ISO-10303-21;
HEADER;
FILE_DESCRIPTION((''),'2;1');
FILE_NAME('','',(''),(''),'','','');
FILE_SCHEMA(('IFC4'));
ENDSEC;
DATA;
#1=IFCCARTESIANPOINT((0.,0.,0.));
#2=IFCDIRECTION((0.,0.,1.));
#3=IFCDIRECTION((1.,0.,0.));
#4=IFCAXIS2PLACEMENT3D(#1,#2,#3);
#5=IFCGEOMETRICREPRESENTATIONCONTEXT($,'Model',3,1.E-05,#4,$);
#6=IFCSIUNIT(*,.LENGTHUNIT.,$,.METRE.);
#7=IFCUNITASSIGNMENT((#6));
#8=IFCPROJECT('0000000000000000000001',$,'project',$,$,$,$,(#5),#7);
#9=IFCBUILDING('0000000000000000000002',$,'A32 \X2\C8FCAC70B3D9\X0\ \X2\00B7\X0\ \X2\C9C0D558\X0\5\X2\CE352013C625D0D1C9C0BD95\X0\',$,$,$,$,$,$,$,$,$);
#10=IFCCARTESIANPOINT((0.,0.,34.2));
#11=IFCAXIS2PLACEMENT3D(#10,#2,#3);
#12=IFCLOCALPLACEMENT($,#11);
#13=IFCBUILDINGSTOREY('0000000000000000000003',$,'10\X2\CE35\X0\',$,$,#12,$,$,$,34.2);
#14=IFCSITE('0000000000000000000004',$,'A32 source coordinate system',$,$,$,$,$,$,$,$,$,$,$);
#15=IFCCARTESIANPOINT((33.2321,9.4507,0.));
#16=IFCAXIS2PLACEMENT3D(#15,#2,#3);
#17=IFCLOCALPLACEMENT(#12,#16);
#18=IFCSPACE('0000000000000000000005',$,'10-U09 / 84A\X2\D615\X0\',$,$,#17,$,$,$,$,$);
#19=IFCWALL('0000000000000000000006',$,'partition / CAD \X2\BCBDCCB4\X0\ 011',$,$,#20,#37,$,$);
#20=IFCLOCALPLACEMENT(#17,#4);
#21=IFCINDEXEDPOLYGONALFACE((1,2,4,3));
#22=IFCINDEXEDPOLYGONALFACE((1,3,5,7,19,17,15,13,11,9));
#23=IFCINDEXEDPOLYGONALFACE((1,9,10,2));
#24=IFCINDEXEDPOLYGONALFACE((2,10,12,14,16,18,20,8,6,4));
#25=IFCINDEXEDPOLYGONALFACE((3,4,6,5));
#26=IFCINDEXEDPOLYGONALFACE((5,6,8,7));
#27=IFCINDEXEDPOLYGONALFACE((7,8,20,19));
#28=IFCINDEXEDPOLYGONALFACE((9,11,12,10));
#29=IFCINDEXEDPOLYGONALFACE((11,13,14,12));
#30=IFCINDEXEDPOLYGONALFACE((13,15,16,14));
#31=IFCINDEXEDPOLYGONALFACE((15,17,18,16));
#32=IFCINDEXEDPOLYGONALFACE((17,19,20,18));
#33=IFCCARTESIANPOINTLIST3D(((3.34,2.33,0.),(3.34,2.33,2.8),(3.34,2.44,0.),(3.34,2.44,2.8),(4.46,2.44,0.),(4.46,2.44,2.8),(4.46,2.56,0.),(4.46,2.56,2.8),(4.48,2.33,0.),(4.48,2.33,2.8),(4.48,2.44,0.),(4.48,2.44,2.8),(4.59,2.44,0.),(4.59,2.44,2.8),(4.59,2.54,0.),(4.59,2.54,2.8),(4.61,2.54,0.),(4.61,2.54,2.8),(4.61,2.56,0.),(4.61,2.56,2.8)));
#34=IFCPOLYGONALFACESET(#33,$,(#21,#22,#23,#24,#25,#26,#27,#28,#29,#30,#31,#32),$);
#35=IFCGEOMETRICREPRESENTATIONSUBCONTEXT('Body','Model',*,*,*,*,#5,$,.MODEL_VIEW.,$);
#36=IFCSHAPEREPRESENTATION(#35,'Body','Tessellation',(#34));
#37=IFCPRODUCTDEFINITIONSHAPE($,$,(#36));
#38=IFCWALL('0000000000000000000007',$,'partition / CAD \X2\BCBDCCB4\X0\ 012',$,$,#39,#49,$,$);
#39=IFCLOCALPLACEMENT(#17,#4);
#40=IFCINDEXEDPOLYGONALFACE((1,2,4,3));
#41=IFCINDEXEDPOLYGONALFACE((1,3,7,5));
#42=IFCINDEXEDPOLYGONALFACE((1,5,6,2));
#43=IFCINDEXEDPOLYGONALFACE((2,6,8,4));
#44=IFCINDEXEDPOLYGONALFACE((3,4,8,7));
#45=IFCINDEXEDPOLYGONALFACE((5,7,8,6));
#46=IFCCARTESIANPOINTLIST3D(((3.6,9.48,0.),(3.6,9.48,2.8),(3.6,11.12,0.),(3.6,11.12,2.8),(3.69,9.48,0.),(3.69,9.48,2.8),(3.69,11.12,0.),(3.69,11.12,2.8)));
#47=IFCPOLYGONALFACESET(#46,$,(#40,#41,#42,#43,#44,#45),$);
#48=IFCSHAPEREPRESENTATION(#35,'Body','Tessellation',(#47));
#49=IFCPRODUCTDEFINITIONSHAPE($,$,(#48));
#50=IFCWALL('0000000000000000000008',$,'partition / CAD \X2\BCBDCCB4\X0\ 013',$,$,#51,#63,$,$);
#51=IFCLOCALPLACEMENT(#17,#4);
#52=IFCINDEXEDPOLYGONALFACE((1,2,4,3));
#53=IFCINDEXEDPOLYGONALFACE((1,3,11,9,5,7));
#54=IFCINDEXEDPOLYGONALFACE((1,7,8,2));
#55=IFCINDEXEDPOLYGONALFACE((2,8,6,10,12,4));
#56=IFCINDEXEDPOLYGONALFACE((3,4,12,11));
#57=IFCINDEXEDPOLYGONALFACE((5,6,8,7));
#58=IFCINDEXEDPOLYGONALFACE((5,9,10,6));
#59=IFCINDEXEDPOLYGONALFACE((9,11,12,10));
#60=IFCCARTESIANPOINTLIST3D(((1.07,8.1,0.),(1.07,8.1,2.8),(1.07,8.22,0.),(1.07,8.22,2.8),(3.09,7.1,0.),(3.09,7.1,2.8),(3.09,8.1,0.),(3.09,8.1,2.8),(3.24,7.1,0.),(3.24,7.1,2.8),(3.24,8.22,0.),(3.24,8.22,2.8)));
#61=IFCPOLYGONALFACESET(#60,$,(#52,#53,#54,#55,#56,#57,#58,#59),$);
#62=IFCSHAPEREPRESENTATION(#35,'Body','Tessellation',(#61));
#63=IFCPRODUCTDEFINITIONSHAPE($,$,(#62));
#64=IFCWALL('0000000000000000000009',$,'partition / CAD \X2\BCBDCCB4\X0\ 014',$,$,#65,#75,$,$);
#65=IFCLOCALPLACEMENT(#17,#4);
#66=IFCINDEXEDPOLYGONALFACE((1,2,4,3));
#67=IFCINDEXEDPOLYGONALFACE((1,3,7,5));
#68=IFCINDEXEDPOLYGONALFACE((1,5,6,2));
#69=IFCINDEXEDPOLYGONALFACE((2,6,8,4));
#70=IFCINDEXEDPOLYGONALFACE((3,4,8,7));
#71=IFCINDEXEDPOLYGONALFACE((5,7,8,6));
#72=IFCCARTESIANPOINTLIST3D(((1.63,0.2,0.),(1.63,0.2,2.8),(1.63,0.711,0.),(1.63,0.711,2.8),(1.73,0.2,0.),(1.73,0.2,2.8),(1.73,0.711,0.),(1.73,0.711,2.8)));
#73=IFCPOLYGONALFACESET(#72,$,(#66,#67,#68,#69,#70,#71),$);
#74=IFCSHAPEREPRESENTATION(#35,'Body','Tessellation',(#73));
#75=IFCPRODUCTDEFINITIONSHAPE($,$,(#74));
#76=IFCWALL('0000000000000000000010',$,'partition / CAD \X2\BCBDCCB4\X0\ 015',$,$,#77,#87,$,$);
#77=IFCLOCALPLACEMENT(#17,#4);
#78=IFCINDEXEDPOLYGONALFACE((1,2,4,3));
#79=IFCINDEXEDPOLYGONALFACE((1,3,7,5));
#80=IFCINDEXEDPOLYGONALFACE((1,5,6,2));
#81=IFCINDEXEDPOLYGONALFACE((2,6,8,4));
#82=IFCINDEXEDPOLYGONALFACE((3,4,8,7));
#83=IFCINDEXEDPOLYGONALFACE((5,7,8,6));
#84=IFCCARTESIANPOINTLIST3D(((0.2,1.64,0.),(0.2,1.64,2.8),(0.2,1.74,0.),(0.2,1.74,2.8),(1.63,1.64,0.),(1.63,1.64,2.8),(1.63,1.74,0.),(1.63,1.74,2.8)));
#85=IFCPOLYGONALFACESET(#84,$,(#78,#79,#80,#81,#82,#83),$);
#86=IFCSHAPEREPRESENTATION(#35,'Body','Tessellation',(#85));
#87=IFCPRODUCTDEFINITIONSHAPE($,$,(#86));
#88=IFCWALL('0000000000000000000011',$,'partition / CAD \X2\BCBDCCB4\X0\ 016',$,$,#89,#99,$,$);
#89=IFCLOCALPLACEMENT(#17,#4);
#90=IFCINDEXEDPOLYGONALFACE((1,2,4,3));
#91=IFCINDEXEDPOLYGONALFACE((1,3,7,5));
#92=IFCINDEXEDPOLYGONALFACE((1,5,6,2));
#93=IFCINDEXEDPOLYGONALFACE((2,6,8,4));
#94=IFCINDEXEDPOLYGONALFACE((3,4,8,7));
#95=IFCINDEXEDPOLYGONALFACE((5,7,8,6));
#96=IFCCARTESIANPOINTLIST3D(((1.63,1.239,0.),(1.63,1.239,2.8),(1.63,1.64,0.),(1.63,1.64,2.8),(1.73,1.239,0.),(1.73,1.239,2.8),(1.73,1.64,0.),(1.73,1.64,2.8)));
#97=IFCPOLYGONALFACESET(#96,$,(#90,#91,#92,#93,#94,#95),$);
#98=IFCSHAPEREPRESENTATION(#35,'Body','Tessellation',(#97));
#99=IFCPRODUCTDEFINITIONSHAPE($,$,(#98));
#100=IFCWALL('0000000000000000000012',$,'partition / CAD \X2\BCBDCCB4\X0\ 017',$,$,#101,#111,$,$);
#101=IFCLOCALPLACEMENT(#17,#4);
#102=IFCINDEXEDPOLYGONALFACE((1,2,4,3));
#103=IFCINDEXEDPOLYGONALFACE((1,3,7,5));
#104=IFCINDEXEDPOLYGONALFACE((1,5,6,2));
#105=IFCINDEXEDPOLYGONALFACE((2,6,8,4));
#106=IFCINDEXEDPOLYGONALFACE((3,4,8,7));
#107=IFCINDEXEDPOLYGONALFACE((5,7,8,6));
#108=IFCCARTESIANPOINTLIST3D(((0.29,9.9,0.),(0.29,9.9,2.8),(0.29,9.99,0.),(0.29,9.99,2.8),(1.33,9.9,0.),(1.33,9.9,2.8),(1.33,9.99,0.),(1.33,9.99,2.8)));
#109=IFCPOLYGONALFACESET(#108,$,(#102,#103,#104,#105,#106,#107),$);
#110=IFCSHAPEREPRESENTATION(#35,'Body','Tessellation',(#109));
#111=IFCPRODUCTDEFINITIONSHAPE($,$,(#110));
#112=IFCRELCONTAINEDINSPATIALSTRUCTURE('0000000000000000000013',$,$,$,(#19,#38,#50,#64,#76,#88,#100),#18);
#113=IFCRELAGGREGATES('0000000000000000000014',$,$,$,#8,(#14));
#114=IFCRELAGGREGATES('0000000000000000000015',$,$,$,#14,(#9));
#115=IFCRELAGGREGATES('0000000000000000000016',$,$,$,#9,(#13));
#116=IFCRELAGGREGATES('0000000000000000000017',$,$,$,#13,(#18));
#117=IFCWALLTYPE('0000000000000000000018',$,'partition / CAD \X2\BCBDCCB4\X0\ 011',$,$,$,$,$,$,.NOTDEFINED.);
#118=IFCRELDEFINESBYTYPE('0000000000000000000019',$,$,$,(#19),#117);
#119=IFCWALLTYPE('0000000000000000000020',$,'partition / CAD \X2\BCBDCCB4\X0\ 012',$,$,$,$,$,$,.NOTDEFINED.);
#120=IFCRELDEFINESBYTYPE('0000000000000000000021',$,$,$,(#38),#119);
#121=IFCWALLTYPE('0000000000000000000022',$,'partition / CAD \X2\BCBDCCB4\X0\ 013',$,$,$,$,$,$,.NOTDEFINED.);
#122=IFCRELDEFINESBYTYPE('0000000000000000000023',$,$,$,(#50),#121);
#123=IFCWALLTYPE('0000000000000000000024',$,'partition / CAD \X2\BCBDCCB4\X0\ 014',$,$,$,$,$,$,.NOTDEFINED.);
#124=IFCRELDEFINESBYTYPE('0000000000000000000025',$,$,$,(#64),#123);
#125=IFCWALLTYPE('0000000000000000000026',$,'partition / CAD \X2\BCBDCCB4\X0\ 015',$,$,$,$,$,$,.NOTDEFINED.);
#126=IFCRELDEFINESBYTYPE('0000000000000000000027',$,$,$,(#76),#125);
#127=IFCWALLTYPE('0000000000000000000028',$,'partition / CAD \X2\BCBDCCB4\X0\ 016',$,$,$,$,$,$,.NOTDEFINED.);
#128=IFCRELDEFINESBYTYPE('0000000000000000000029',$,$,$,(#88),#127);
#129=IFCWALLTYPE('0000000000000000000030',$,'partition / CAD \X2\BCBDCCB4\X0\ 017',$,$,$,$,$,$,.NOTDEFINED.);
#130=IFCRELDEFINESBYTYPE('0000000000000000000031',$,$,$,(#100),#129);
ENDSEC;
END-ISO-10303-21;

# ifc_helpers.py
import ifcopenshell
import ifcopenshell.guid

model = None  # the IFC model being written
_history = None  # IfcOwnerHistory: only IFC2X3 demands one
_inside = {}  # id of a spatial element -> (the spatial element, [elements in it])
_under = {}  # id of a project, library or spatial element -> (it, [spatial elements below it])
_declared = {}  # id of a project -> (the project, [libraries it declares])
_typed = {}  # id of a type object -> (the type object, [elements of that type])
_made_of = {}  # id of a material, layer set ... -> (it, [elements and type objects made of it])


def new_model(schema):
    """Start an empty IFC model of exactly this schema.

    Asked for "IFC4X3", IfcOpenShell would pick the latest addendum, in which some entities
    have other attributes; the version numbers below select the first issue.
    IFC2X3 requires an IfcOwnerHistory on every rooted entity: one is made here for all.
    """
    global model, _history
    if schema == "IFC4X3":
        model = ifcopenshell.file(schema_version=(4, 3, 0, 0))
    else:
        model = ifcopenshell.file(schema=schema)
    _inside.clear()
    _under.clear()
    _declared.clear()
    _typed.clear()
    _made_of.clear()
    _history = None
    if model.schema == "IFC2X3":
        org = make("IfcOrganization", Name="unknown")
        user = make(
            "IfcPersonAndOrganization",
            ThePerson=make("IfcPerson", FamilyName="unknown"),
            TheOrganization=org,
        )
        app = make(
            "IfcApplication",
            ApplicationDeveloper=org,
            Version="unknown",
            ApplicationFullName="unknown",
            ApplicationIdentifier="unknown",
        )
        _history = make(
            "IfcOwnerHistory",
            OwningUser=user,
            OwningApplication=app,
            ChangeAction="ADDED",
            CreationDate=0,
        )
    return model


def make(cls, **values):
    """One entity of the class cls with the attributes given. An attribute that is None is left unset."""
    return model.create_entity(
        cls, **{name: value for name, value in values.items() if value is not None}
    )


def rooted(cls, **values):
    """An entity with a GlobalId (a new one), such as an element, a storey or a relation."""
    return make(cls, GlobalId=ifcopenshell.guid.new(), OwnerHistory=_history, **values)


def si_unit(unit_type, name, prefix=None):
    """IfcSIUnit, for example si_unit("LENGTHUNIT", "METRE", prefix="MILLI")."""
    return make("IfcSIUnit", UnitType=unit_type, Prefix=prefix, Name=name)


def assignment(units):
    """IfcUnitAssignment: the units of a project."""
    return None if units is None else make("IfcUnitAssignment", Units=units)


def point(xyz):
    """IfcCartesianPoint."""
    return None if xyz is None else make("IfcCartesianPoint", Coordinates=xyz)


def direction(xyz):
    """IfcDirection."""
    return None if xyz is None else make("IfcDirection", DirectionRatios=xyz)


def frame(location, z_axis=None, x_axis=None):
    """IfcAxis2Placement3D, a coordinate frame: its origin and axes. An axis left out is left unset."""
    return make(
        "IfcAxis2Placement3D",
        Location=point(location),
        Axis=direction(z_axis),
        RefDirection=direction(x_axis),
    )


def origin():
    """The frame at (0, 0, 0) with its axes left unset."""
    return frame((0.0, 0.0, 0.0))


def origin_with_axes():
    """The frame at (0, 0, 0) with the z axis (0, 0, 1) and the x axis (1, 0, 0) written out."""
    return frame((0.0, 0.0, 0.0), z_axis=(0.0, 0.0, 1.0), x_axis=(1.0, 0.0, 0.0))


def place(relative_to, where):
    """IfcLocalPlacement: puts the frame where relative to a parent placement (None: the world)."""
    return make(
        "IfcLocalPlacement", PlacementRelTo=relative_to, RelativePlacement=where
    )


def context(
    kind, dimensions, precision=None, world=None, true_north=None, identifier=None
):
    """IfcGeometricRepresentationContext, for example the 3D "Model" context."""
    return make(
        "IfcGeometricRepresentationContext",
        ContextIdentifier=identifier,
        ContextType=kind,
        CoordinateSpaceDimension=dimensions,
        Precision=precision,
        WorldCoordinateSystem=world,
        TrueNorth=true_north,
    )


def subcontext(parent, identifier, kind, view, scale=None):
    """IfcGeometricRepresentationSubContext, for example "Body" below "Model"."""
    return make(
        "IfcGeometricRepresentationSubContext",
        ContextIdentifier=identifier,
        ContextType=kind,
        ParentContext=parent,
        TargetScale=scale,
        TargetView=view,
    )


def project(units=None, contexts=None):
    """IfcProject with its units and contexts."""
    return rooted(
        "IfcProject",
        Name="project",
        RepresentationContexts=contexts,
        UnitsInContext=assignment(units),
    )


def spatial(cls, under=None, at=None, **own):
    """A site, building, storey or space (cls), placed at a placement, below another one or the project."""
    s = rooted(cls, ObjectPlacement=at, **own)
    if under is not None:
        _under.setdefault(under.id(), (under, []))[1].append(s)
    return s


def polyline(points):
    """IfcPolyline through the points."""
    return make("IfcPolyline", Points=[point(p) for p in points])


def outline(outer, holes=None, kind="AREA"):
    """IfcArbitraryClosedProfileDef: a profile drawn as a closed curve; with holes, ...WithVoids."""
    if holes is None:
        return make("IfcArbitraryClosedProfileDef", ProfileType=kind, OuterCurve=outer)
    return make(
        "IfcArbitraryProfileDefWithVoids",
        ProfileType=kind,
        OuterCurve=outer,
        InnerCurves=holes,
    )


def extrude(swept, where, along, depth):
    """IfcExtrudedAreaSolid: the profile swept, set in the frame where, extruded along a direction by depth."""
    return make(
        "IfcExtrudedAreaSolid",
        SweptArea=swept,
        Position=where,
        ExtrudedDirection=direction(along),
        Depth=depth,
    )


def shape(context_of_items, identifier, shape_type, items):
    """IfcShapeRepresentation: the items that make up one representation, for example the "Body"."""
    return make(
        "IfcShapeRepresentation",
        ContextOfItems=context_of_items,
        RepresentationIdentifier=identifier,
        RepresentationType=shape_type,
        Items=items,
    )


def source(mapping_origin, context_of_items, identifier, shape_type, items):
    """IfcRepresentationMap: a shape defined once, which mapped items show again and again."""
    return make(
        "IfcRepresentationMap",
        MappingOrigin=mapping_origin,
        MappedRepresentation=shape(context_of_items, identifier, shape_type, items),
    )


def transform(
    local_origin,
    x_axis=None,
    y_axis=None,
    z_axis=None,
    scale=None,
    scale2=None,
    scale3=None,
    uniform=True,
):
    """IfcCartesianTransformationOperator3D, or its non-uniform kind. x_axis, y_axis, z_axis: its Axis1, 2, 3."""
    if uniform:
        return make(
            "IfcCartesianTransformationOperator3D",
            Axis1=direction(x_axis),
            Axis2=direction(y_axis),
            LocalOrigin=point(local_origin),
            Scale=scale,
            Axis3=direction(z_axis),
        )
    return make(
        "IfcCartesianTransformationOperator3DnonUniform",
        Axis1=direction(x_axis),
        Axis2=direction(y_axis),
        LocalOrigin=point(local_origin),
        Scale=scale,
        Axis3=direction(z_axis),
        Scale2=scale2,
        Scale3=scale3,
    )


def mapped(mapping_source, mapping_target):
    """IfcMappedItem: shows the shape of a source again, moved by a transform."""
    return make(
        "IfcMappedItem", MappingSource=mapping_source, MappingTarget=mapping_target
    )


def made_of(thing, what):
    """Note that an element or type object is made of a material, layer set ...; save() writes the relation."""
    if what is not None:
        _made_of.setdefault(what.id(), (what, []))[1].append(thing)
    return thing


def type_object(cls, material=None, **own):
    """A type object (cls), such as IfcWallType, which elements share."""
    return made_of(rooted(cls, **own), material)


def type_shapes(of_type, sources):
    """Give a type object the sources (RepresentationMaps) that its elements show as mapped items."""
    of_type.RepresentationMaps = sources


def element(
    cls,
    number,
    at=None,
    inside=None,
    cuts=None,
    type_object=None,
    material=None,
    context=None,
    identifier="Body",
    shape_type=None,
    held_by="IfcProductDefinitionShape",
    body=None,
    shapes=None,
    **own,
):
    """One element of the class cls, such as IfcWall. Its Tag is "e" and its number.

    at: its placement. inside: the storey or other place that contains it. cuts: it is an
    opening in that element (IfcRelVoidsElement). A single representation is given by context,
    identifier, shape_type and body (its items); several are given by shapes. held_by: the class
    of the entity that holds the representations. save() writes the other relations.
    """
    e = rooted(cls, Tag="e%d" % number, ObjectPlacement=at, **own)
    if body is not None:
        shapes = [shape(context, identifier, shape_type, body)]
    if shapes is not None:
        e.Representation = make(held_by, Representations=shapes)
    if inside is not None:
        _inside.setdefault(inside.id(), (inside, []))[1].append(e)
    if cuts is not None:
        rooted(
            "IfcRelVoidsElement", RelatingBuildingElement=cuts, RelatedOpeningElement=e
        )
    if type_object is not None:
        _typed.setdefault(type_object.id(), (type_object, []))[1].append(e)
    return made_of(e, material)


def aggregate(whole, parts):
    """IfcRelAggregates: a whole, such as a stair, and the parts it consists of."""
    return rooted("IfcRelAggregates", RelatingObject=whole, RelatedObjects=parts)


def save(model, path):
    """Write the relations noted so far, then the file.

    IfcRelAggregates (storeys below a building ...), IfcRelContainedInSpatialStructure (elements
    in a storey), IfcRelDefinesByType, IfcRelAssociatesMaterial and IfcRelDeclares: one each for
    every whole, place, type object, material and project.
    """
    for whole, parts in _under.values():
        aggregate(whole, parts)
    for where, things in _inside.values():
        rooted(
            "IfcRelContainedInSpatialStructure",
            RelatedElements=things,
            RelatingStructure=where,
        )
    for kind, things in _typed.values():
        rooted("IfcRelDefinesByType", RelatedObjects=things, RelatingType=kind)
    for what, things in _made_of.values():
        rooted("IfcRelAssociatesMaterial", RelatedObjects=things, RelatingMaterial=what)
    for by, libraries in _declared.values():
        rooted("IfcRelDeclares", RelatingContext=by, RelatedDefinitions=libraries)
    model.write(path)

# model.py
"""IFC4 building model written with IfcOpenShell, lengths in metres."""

from ifc_helpers import new_model, si_unit, frame, origin, origin_with_axes, place, context, subcontext, project, spatial, polyline, outline, extrude, source, transform, mapped, type_object, type_shapes, element, save


model = new_model("IFC4")

# Units and contexts
model_context = context("Model", 3, precision=1e-05, world=origin_with_axes())
body_context = subcontext(model_context, "Body", "Model", "MODEL_VIEW")
ifc_project = project(units=[si_unit("LENGTHUNIT", "METRE")], contexts=[model_context])

# Site, building, storey, space
storey_placement = place(None, frame((0.0, 0.0, 34.2), z_axis=(0.0, 0.0, 1.0), x_axis=(1.0, 0.0, 0.0)))
space_placement = place(storey_placement, frame((33.2321, 9.4507, 0.0), z_axis=(0.0, 0.0, 1.0), x_axis=(1.0, 0.0, 0.0)))
site = spatial("IfcSite", under=ifc_project, Name="A32 source coordinate system")
building = spatial("IfcBuilding", under=site, Name="A32 주거동 · 지하5층–옥탑지붕")
storey = spatial("IfcBuildingStorey", under=building, at=storey_placement, Name="10층", Elevation=34.2)
space = spatial("IfcSpace", under=storey, at=space_placement, Name="10-U09 / 84A형")

# Walls
wall_type_1 = type_object("IfcWallType", Name="partition / CAD 벽체 011", PredefinedType="NOTDEFINED")
shared_shape_1 = source(origin(), body_context, "Body", "SweptSolid", [
    extrude(outline(polyline([(3.34, 2.33), (3.34, 2.44), (4.46, 2.44), (4.46, 2.56), (4.61, 2.56), (4.61, 2.54), (4.59, 2.54), (4.59, 2.44), (4.48, 2.44), (4.48, 2.33), (3.34, 2.33)])), origin(), (0.0, 0.0, 1.0), 2.8),
])
type_shapes(wall_type_1, [shared_shape_1])
wall_1_placement = place(space_placement, origin_with_axes())
element("IfcWall", 1, at=wall_1_placement, inside=space, type_object=wall_type_1, Name="partition / CAD 벽체 011", context=body_context, shape_type="MappedRepresentation", body=[
    mapped(shared_shape_1, transform((0.0, 0.0, 0.0), scale=1.0)),
])
wall_type_2 = type_object("IfcWallType", Name="partition / CAD 벽체 012", PredefinedType="NOTDEFINED")
shared_shape_2 = source(origin(), body_context, "Body", "SweptSolid", [
    extrude(outline(polyline([(3.6, 11.12), (3.69, 11.12), (3.69, 9.48), (3.6, 9.48), (3.6, 11.12)])), origin(), (0.0, 0.0, 1.0), 2.8),
])
type_shapes(wall_type_2, [shared_shape_2])
wall_2_placement = place(space_placement, origin_with_axes())
element("IfcWall", 2, at=wall_2_placement, inside=space, type_object=wall_type_2, Name="partition / CAD 벽체 012", context=body_context, shape_type="MappedRepresentation", body=[
    mapped(shared_shape_2, transform((0.0, 0.0, 0.0), scale=1.0)),
])
wall_type_3 = type_object("IfcWallType", Name="partition / CAD 벽체 013", PredefinedType="NOTDEFINED")
shared_shape_3 = source(origin(), body_context, "Body", "SweptSolid", [
    extrude(outline(polyline([(3.09, 8.1), (1.07, 8.1), (1.07, 8.22), (3.24, 8.22), (3.24, 7.1), (3.09, 7.1), (3.09, 8.1)])), origin(), (0.0, 0.0, 1.0), 2.8),
])
type_shapes(wall_type_3, [shared_shape_3])
wall_3_placement = place(space_placement, origin_with_axes())
element("IfcWall", 3, at=wall_3_placement, inside=space, type_object=wall_type_3, Name="partition / CAD 벽체 013", context=body_context, shape_type="MappedRepresentation", body=[
    mapped(shared_shape_3, transform((0.0, 0.0, 0.0), scale=1.0)),
])
wall_type_4 = type_object("IfcWallType", Name="partition / CAD 벽체 014", PredefinedType="NOTDEFINED")
shared_shape_4 = source(origin(), body_context, "Body", "SweptSolid", [
    extrude(outline(polyline([(1.73, 0.2), (1.63, 0.2), (1.63, 0.711), (1.73, 0.711), (1.73, 0.2)])), origin(), (0.0, 0.0, 1.0), 2.8),
])
type_shapes(wall_type_4, [shared_shape_4])
wall_4_placement = place(space_placement, origin_with_axes())
element("IfcWall", 4, at=wall_4_placement, inside=space, type_object=wall_type_4, Name="partition / CAD 벽체 014", context=body_context, shape_type="MappedRepresentation", body=[
    mapped(shared_shape_4, transform((0.0, 0.0, 0.0), scale=1.0)),
])
wall_type_5 = type_object("IfcWallType", Name="partition / CAD 벽체 015", PredefinedType="NOTDEFINED")
shared_shape_5 = source(origin(), body_context, "Body", "SweptSolid", [
    extrude(outline(polyline([(1.63, 1.74), (1.63, 1.64), (0.2, 1.64), (0.2, 1.74), (1.63, 1.74)])), origin(), (0.0, 0.0, 1.0), 2.8),
])
type_shapes(wall_type_5, [shared_shape_5])
wall_5_placement = place(space_placement, origin_with_axes())
element("IfcWall", 5, at=wall_5_placement, inside=space, type_object=wall_type_5, Name="partition / CAD 벽체 015", context=body_context, shape_type="MappedRepresentation", body=[
    mapped(shared_shape_5, transform((0.0, 0.0, 0.0), scale=1.0)),
])
wall_type_6 = type_object("IfcWallType", Name="partition / CAD 벽체 016", PredefinedType="NOTDEFINED")
shared_shape_6 = source(origin(), body_context, "Body", "SweptSolid", [
    extrude(outline(polyline([(1.73, 1.239), (1.63, 1.239), (1.63, 1.64), (1.73, 1.64), (1.73, 1.239)])), origin(), (0.0, 0.0, 1.0), 2.8),
])
type_shapes(wall_type_6, [shared_shape_6])
wall_6_placement = place(space_placement, origin_with_axes())
element("IfcWall", 6, at=wall_6_placement, inside=space, type_object=wall_type_6, Name="partition / CAD 벽체 016", context=body_context, shape_type="MappedRepresentation", body=[
    mapped(shared_shape_6, transform((0.0, 0.0, 0.0), scale=1.0)),
])
wall_type_7 = type_object("IfcWallType", Name="partition / CAD 벽체 017", PredefinedType="NOTDEFINED")
shared_shape_7 = source(origin(), body_context, "Body", "SweptSolid", [
    extrude(outline(polyline([(1.33, 9.99), (1.33, 9.9), (0.29, 9.9), (0.29, 9.99), (1.33, 9.99)])), origin(), (0.0, 0.0, 1.0), 2.8),
])
type_shapes(wall_type_7, [shared_shape_7])
wall_7_placement = place(space_placement, origin_with_axes())
element("IfcWall", 7, at=wall_7_placement, inside=space, type_object=wall_type_7, Name="partition / CAD 벽체 017", context=body_context, shape_type="MappedRepresentation", body=[
    mapped(shared_shape_7, transform((0.0, 0.0, 0.0), scale=1.0)),
])

save(model, "model.ifc")
